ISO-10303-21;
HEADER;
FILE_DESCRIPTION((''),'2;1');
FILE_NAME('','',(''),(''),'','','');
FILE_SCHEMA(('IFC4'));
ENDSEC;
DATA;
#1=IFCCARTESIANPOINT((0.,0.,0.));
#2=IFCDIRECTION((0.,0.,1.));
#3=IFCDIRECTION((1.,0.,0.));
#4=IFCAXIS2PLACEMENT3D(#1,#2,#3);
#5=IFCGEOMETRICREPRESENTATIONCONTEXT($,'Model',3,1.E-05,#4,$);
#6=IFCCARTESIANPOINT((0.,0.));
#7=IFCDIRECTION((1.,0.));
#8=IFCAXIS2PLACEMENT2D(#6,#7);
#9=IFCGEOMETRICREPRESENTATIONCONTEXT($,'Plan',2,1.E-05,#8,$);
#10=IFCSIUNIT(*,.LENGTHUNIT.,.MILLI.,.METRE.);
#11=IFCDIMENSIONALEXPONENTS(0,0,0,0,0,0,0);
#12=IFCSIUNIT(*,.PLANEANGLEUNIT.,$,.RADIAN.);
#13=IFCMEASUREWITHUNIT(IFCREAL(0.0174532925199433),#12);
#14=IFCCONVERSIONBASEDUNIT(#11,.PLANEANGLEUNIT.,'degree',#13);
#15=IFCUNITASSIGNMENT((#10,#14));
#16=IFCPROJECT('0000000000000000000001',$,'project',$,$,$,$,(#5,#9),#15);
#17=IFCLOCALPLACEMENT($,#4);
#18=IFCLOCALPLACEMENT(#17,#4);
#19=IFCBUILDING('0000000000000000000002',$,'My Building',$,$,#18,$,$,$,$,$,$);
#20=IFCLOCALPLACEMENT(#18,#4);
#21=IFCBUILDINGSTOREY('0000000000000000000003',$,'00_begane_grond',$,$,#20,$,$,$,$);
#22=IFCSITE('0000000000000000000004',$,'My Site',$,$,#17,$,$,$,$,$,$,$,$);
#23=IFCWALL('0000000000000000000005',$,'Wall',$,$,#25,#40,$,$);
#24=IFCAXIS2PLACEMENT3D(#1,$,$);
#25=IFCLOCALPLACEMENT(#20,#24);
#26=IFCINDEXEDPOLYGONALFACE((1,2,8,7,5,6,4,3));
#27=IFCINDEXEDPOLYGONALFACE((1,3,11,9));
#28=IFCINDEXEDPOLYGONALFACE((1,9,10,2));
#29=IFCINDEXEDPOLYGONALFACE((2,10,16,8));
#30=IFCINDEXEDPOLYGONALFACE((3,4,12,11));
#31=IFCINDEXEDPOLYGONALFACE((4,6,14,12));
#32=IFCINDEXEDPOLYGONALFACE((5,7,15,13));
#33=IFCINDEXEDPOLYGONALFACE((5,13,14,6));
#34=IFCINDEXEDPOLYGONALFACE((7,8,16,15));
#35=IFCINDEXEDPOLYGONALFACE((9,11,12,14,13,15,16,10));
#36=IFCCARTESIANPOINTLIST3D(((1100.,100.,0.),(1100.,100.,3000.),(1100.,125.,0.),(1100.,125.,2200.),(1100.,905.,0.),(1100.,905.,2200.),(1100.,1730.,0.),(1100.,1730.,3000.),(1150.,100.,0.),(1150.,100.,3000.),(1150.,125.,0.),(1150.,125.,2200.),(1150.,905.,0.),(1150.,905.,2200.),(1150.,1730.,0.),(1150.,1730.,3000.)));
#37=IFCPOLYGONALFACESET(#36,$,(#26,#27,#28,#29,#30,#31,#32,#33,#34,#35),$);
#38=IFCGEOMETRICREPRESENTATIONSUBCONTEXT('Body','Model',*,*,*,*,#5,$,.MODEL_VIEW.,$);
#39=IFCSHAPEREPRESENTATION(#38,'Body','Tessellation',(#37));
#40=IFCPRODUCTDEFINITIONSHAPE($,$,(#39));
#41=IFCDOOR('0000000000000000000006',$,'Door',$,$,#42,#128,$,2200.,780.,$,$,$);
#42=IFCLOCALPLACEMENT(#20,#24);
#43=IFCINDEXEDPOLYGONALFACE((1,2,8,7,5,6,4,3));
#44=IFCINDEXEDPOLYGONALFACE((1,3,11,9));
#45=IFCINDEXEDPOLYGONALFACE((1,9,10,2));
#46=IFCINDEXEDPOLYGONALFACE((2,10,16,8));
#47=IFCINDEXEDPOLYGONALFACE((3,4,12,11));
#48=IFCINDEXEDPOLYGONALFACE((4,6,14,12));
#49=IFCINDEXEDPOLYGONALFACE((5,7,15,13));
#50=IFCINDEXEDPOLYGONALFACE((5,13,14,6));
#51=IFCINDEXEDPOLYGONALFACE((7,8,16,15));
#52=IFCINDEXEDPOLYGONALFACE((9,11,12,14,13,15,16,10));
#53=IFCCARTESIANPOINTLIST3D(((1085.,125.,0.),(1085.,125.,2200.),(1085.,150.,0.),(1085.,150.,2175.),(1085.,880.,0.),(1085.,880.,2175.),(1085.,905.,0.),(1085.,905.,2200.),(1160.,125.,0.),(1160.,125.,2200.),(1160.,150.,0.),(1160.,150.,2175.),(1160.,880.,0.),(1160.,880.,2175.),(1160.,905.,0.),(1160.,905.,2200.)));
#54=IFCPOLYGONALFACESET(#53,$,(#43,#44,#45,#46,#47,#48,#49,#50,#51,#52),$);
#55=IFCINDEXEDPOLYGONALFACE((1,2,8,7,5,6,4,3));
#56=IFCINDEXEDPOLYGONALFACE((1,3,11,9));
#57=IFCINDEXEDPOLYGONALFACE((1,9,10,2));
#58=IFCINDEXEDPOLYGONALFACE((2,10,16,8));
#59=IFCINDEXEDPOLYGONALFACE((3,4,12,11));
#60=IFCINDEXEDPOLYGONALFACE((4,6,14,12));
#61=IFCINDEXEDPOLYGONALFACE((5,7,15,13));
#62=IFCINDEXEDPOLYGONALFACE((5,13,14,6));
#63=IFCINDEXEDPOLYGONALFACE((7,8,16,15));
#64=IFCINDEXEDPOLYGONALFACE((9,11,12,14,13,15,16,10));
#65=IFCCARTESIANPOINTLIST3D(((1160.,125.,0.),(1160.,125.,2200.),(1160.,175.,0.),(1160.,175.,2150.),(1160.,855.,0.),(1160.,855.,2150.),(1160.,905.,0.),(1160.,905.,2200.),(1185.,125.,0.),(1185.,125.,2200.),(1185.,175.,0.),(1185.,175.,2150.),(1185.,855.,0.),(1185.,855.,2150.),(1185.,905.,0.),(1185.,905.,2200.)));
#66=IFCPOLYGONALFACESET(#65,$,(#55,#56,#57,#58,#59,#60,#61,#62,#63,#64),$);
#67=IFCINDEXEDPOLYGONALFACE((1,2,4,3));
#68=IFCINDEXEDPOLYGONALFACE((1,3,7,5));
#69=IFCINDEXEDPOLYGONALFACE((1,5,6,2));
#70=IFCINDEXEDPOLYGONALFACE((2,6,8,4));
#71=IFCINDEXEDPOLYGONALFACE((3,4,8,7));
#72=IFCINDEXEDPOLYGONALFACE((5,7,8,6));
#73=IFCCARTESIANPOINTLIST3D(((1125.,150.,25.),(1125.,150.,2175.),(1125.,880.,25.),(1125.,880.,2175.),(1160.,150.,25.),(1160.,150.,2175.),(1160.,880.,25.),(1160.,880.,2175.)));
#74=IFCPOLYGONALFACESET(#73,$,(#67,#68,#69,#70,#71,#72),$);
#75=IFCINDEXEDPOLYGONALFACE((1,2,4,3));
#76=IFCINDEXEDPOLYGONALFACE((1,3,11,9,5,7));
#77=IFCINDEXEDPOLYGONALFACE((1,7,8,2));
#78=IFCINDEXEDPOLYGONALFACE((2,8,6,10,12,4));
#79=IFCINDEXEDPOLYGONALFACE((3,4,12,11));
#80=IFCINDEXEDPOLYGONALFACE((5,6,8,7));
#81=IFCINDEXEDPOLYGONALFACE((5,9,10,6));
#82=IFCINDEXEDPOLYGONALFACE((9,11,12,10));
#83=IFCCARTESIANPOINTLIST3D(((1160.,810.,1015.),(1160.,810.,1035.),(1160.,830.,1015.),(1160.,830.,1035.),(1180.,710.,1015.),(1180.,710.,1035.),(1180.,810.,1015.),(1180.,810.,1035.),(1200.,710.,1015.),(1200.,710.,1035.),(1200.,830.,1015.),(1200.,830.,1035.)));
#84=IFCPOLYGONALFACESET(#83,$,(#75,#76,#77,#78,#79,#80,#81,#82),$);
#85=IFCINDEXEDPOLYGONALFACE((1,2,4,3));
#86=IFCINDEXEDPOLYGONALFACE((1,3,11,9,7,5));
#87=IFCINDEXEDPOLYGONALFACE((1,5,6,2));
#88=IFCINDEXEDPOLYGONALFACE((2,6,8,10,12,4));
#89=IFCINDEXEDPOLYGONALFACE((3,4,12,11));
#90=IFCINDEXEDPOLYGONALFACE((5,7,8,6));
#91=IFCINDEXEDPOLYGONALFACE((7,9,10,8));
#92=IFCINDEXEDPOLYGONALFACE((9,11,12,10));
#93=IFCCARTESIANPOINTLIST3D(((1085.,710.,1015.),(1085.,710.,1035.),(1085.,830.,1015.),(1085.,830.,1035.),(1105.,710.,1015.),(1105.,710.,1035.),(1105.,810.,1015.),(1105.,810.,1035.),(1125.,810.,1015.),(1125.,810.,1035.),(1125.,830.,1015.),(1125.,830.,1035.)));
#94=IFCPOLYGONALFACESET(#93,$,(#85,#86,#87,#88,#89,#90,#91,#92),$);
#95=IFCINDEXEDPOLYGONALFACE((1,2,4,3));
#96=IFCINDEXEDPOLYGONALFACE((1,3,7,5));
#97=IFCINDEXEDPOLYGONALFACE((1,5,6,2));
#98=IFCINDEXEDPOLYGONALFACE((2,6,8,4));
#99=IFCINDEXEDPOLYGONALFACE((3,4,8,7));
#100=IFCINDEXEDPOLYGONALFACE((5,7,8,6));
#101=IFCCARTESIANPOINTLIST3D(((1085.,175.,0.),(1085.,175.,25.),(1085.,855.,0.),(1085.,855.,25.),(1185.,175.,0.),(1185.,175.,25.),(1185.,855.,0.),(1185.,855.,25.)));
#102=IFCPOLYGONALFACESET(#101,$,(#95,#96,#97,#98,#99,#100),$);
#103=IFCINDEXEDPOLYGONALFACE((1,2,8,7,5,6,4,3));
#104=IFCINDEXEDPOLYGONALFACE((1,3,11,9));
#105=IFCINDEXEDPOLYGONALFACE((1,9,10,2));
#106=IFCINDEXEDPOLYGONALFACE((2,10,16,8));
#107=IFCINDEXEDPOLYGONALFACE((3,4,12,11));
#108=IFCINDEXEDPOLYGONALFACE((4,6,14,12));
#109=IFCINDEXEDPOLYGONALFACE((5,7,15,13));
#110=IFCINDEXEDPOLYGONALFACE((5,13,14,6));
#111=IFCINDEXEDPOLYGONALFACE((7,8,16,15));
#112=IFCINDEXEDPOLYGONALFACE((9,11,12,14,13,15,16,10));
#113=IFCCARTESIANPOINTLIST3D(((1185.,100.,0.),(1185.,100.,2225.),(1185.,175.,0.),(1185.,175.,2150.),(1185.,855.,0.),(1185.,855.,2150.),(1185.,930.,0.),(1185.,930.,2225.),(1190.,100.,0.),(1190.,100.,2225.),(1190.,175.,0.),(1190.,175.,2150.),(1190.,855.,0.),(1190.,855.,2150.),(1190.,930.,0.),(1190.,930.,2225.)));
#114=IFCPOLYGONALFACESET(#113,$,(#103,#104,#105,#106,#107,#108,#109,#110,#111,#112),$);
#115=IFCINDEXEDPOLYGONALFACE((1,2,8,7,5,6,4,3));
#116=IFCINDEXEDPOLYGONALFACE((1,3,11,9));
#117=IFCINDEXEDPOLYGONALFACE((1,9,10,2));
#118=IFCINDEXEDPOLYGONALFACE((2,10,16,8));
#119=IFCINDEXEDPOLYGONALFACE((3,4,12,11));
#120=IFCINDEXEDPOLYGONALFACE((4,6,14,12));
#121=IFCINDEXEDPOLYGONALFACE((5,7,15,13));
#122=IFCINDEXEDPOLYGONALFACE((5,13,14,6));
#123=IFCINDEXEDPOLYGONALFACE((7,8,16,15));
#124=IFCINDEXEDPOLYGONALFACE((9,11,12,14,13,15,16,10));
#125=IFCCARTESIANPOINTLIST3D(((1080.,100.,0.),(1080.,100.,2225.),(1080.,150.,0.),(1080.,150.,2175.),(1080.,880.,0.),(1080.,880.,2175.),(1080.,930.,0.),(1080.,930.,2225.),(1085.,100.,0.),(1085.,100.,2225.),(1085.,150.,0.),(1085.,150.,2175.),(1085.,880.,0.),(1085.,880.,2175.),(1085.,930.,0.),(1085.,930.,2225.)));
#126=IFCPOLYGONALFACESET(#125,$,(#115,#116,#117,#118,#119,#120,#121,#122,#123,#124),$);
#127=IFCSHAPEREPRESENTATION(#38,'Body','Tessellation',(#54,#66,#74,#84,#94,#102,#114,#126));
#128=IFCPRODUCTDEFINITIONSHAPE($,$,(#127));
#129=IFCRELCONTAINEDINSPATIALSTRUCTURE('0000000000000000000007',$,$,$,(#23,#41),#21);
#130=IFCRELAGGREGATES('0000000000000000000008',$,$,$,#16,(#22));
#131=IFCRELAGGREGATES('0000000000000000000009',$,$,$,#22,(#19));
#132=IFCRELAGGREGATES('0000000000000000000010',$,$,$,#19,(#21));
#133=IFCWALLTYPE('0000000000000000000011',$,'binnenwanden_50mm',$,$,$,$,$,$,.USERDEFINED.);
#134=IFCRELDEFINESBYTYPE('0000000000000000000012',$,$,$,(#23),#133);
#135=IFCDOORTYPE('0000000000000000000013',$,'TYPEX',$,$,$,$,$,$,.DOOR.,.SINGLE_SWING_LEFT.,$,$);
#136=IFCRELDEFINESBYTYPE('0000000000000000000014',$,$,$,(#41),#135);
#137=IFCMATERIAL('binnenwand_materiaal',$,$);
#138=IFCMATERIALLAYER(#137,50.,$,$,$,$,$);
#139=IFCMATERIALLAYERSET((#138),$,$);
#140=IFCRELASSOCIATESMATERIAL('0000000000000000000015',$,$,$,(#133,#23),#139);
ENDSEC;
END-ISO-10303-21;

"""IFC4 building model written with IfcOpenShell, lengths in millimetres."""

from ifc_helpers import new_model, entity, si_unit, converted_unit, frame, origin_with_axes, origin_2d_with_axis, place, context, subcontext, project, spatial, line, indexed_curve, outline, extrude, shape, source, transform, mapped, material, layer, layer_set, layer_usage, type_object, type_shapes, element, fill, save


model = new_model("IFC4")

# Units and contexts
model_context = context("Model", 3, precision=1e-05, world=origin_with_axes())
plan_context = context("Plan", 2, precision=1e-05, world=origin_2d_with_axis())
body_context_1 = subcontext(model_context, "Body", "Model", "MODEL_VIEW")
body_context_2 = subcontext(plan_context, "Body", "Plan", "PLAN_VIEW")
ifc_project = project(units=[si_unit("LENGTHUNIT", "METRE", prefix="MILLI"), converted_unit("PLANEANGLEUNIT", "degree", entity("IfcReal", 0.0174532925199433), si_unit("PLANEANGLEUNIT", "RADIAN"), dimensions=[0, 0, 0, 0, 0, 0, 0])], contexts=[model_context, plan_context])

# Site, building, storey
site_placement = place(None, origin_with_axes())
site = spatial("IfcSite", under=ifc_project, at=site_placement, Name="My Site")
building_placement = place(site_placement, origin_with_axes())
building = spatial("IfcBuilding", under=site, at=building_placement, Name="My Building")
storey_placement = place(building_placement, origin_with_axes())
storey = spatial("IfcBuildingStorey", under=building, at=storey_placement, Name="00_begane_grond")

# Shared definitions
shared_shape_1 = source(origin_with_axes(), body_context_1, "Body", "SweptSolid", [
    extrude(outline(indexed_curve([(0.0, 0.0), (780.0, 0.0), (780.0, 2200.0), (0.0, 2200.0)], segments=[line(1, 2, 3, 4, 1)])), frame((0.0, -100.0, 0.0), z_axis=(0.0, -1.0, 0.0), x_axis=(1.0, 0.0, 0.0)), (0.0, 0.0, -1.0), 300.0),
])
door_type = type_object("IfcDoorType", Name="TYPEX", OperationType="SINGLE_SWING_LEFT", PredefinedType="DOOR")
shared_shape_2 = source(origin_with_axes(), body_context_1, "Body", "SweptSolid", [
    extrude(outline(indexed_curve([(0.0, 0.0), (0.0, 2200.0), (780.0, 2200.0), (780.0, 0.0), (755.0, 0.0), (755.0, 2175.0), (25.0, 2175.0), (25.0, 0.0)], segments=[line(1, 2, 3, 4, 5, 6, 7, 8, 1)])), frame((0.0, 25.0, 0.0), z_axis=(0.0, -1.0, 0.0), x_axis=(1.0, 0.0, 0.0)), (0.0, 0.0, -1.0), 75.0),
    extrude(outline(indexed_curve([(0.0, 0.0), (0.0, 2200.0), (780.0, 2200.0), (780.0, 0.0), (730.0, 0.0), (730.0, 2150.0), (50.0, 2150.0), (50.0, 0.0)], segments=[line(1, 2, 3, 4, 5, 6, 7, 8, 1)])), frame((0.0, 0.0, 0.0), z_axis=(0.0, -1.0, 0.0), x_axis=(1.0, 0.0, 0.0)), (0.0, 0.0, -1.0), 25.0),
    extrude(outline(indexed_curve([(0.0, 0.0), (730.0, 0.0), (730.0, 35.0), (0.0, 35.0)], segments=[line(1, 2, 3, 4, 1)])), frame((25.0, 25.0, 25.0), z_axis=(0.0, 0.0, 1.0), x_axis=(1.0, 0.0, 0.0)), (0.0, 0.0, 1.0), 2150.0),
    extrude(outline(indexed_curve([(0.0, 0.0), (0.0, -40.0), (-120.0, -40.0), (-120.0, -20.0), (-20.0, -20.0), (-20.0, 0.0)], segments=[line(1, 2, 3, 4, 5, 6, 1)])), frame((705.0, 25.0, 1015.0), z_axis=(0.0, 0.0, 1.0), x_axis=(1.0, 0.0, 0.0)), (0.0, 0.0, 1.0), 20.0),
    extrude(outline(indexed_curve([(0.0, 0.0), (0.0, 40.0), (-120.0, 40.0), (-120.0, 20.0), (-20.0, 20.0), (-20.0, 0.0)], segments=[line(1, 2, 3, 4, 5, 6, 1)])), frame((705.0, 60.0, 1015.0), z_axis=(0.0, 0.0, 1.0), x_axis=(1.0, 0.0, 0.0)), (0.0, 0.0, 1.0), 20.0),
    extrude(outline(indexed_curve([(0.0, 0.0), (680.0, 0.0), (680.0, 100.0), (0.0, 100.0)], segments=[line(1, 2, 3, 4, 1)])), frame((50.0, 0.0, 0.0), z_axis=(0.0, 0.0, 1.0), x_axis=(1.0, 0.0, 0.0)), (0.0, 0.0, 1.0), 25.0),
    extrude(outline(indexed_curve([(0.0, 0.0), (0.0, 2225.0), (830.0, 2225.0), (830.0, 0.0), (755.0, 0.0), (755.0, 2150.0), (75.0, 2150.0), (75.0, 0.0)], segments=[line(1, 2, 3, 4, 5, 6, 7, 8, 1)])), frame((-25.0, -5.0, 0.0), z_axis=(0.0, -1.0, 0.0), x_axis=(1.0, 0.0, 0.0)), (0.0, 0.0, -1.0), 5.0),
    extrude(outline(indexed_curve([(0.0, 0.0), (0.0, 2225.0), (830.0, 2225.0), (830.0, 0.0), (780.0, 0.0), (780.0, 2175.0), (50.0, 2175.0), (50.0, 0.0)], segments=[line(1, 2, 3, 4, 5, 6, 7, 8, 1)])), frame((-25.0, 100.0, 0.0), z_axis=(0.0, -1.0, 0.0), x_axis=(1.0, 0.0, 0.0)), (0.0, 0.0, -1.0), 5.0),
])
shared_shape_3 = source(origin_with_axes(), body_context_2, "Body", "Curve2D", [
    entity("IfcIndexedPolyCurve", entity("IfcCartesianPointList2D", [[0.0, 0.0], [0.0, 100.0], [25.0, 100.0], [25.0, 25.0], [50.0, 25.0], [50.0, 0.0]]), [entity("IfcLineIndex", [1, 2, 3, 4, 5, 6, 1])]),
    entity("IfcIndexedPolyCurve", entity("IfcCartesianPointList2D", [[780.0, 0.0], [780.0, 100.0], [755.0, 100.0], [755.0, 25.0], [730.0, 25.0], [730.0, 0.0]]), [entity("IfcLineIndex", [1, 2, 3, 4, 5, 6, 1])]),
    entity("IfcTrimmedCurve", entity("IfcEllipse", entity("IfcAxis2Placement2D", entity("IfcCartesianPoint", [60.0, 100.0]), entity("IfcDirection", [1.0, 0.0])), 695.0, 730.0), [entity("IfcCartesianPoint", [755.0, 100.0])], [entity("IfcCartesianPoint", [60.0, 830.0])], True, "CARTESIAN"),
    entity("IfcIndexedPolyCurve", entity("IfcCartesianPointList2D", [[25.0, 100.0], [60.0, 100.0], [60.0, 830.0], [25.0, 830.0]]), [entity("IfcLineIndex", [1, 2, 3, 4, 1])]),
])
type_shapes(door_type, [shared_shape_2, shared_shape_3])

# Shared definitions
ifc_material_1 = material(Name="binnenwand_materiaal")
ifc_layer_1 = layer(ifc_material_1, 50.0)
ifc_layer_set_1 = layer_set([ifc_layer_1])
wall_type_1 = type_object("IfcWallType", Name="binnenwanden_50mm", PredefinedType="USERDEFINED", material=ifc_layer_set_1)

# Wall, opening, door
ifc_layer_usage_1 = layer_usage(ifc_layer_set_1, "AXIS2", "POSITIVE", 0.0)
wall_1_placement = place(storey_placement, frame((1100.0, 1730.0, 0.0), z_axis=(0.0, 0.0, 1.0), x_axis=(-0.000001, -1.0, 0.0)))
wall_1 = element("IfcWall", 1, at=wall_1_placement, inside=storey, type_object=wall_type_1, material=ifc_layer_usage_1, Name="Wall", context=body_context_1, shape_type="SweptSolid", body=[
    extrude(outline(indexed_curve([(0.0, 0.0), (0.0, 50.0), (1630.0, 50.0), (1630.0, 0.0), (0.0, 0.0)], self_intersect=False)), origin_with_axes(), (0.0, 0.0, 1.0), 3000.0),
])
opening_1_placement = place(wall_1_placement, frame((1605.0, 85.0, 0.0), z_axis=(0.0, 0.0, 1.0), x_axis=(-1.0, 0.0, 0.0)))
opening_1 = element("IfcOpeningElement", 2, at=opening_1_placement, cuts=wall_1, PredefinedType="OPENING", context=body_context_1, shape_type="MappedRepresentation", body=[
    mapped(shared_shape_1, transform((0.0, 0.0, 0.0), x_axis=(1.0, 0.0, 0.0), y_axis=(0.0, 1.0, 0.0), z_axis=(0.0, 0.0, 1.0), scale=1.0)),
])
door_1_placement = place(opening_1_placement, frame((0.0, 0.0, 0.0), z_axis=(0.0, 0.0, 1.0), x_axis=(1.0, 0.0, 0.0)))
door_1 = element("IfcDoor", 3, at=door_1_placement, inside=storey, type_object=door_type, Name="Door", OverallHeight=2200.0, OverallWidth=780.0, shapes=[
    shape(body_context_1, "Body", "MappedRepresentation", [mapped(shared_shape_2, transform((0.0, 0.0, 0.0), x_axis=(1.0, 0.0, 0.0), y_axis=(0.0, 1.0, 0.0), z_axis=(0.0, 0.0, 1.0), scale=1.0))]),
    shape(body_context_2, "Body", "MappedRepresentation", [mapped(shared_shape_3, transform((0.0, 0.0, 0.0), x_axis=(1.0, 0.0, 0.0), y_axis=(0.0, 1.0, 0.0), z_axis=(0.0, 0.0, 1.0), scale=1.0))]),
])
fill(opening_1, door_1)

save(model, "model.ifc")
